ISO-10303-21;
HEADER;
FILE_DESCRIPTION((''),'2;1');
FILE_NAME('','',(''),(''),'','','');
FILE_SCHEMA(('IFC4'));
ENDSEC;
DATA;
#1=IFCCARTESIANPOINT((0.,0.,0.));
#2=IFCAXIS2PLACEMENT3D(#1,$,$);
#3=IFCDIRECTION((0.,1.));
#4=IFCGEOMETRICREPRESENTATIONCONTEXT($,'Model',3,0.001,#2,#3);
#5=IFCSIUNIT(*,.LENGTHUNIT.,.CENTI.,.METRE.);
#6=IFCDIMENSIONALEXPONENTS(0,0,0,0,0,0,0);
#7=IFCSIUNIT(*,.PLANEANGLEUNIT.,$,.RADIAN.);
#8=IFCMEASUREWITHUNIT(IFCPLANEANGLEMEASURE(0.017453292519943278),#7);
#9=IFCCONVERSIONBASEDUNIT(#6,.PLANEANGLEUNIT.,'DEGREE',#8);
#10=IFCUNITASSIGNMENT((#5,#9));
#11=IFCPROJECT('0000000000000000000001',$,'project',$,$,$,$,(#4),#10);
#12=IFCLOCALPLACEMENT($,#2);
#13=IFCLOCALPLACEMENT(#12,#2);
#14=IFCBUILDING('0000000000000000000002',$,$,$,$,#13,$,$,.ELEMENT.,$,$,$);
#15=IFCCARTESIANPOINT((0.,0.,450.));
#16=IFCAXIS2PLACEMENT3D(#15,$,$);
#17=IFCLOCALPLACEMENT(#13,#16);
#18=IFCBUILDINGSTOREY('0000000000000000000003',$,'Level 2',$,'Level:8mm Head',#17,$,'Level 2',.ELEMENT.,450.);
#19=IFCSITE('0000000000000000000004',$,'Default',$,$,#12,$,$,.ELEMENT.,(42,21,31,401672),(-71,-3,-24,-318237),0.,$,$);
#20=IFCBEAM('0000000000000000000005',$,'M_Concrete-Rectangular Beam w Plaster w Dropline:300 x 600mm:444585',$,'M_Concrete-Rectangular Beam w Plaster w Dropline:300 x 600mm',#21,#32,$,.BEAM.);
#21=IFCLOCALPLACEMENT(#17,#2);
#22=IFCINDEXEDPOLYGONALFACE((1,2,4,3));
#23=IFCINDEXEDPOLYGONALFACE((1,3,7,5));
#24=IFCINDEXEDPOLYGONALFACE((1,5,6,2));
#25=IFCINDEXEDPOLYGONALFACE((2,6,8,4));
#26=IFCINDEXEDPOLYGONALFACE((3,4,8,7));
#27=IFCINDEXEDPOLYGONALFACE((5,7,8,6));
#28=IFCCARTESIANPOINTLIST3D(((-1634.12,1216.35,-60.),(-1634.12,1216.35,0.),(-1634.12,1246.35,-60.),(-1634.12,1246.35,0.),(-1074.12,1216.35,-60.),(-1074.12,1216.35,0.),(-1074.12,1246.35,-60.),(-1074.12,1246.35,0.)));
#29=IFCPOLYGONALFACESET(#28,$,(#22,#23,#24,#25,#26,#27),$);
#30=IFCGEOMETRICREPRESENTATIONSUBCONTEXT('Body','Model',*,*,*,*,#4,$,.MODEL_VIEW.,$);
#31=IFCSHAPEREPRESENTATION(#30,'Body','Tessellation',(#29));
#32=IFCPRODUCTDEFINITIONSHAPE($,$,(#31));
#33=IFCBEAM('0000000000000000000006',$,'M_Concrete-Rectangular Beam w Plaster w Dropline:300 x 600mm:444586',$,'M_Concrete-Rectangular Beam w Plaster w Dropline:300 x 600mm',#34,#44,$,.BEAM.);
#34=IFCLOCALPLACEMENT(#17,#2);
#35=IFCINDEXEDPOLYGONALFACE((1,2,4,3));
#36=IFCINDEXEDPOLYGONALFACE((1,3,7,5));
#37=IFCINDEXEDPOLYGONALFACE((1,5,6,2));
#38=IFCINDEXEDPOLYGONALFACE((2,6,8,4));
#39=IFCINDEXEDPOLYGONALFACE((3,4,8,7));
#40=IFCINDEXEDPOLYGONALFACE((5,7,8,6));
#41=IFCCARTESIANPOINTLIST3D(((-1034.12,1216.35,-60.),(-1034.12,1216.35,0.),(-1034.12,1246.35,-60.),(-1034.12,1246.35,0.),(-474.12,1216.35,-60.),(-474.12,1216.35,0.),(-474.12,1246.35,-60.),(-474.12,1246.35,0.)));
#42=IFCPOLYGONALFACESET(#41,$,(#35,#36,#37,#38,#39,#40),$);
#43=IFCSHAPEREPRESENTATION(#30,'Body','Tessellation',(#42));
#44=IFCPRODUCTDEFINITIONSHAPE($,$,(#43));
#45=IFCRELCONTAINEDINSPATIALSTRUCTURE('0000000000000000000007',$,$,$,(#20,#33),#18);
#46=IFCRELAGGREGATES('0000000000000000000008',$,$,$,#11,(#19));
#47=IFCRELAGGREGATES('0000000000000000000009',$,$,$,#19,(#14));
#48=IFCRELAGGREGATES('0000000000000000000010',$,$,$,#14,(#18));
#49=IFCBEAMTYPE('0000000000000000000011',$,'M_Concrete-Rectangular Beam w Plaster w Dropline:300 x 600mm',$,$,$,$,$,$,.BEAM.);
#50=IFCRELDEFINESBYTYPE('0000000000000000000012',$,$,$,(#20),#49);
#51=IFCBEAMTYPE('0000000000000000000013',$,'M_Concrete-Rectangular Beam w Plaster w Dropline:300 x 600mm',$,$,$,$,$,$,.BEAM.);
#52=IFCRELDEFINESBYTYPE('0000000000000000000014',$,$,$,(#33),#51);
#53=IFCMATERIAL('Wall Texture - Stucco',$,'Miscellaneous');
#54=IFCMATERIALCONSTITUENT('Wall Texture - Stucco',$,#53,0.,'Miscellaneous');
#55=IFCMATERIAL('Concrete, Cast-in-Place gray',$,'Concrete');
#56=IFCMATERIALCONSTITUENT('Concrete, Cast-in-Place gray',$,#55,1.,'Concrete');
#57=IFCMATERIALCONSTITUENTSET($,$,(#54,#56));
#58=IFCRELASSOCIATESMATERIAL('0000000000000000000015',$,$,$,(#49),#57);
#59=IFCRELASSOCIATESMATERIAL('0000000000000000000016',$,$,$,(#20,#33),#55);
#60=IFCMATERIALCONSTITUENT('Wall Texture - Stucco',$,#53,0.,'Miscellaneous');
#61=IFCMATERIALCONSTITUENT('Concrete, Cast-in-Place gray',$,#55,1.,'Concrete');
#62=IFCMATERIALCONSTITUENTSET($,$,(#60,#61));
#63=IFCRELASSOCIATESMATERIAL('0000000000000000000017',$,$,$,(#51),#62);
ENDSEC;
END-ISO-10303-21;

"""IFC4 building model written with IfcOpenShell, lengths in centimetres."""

from ifc_helpers import new_model, entity, si_unit, converted_unit, direction, frame, origin, place, context, subcontext, project, spatial, indexed_curve, outline, extrude, source, transform, mapped, material, constituent, constituent_set, type_object, type_shapes, element, save


model = new_model("IFC4")

# Units and contexts
model_context = context("Model", 3, precision=0.001, world=origin(), true_north=direction((0.0, 1.0)))
body_context = subcontext(model_context, "Body", "Model", "MODEL_VIEW")
ifc_project = project(units=[si_unit("LENGTHUNIT", "METRE", prefix="CENTI"), converted_unit("PLANEANGLEUNIT", "DEGREE", entity("IfcPlaneAngleMeasure", 0.017453292519943278), si_unit("PLANEANGLEUNIT", "RADIAN"), dimensions=[0, 0, 0, 0, 0, 0, 0])], contexts=[model_context])

# Site, building, storey
site_placement = place(None, origin())
site = spatial("IfcSite", under=ifc_project, at=site_placement, Name="Default", CompositionType="ELEMENT", RefLatitude=(42, 21, 31, 401672), RefLongitude=(-71, -3, -24, -318237), RefElevation=0.0)
building_placement = place(site_placement, origin())
building = spatial("IfcBuilding", under=site, at=building_placement, CompositionType="ELEMENT")
storey_placement = place(building_placement, frame((0.0, 0.0, 450.0)))
storey = spatial("IfcBuildingStorey", under=building, at=storey_placement, Name="Level 2", ObjectType="Level:8mm Head", LongName="Level 2", CompositionType="ELEMENT", Elevation=450.0)

# Beams
ifc_material_1 = material(Name="Concrete, Cast-in-Place gray", Category="Concrete")
ifc_material_2 = material(Name="Wall Texture - Stucco", Category="Miscellaneous")
ifc_constituent_1 = constituent(ifc_material_2, Name="Wall Texture - Stucco", Category="Miscellaneous", fraction=0.0)
ifc_constituent_2 = constituent(ifc_material_1, Name="Concrete, Cast-in-Place gray", Category="Concrete", fraction=1.0)
ifc_constituent_set_1 = constituent_set(constituents=[ifc_constituent_1, ifc_constituent_2])
beam_type_1 = type_object("IfcBeamType", Name="M_Concrete-Rectangular Beam w Plaster w Dropline:300 x 600mm", PredefinedType="BEAM", material=ifc_constituent_set_1)
shared_shape_1 = source(origin(), body_context, "Body", "SweptSolid", [
    extrude(outline(indexed_curve([(-30.0, -15.0), (30.0, -15.0), (30.0, 15.0), (-30.0, 15.0), (-30.0, -15.0)], self_intersect=False)), frame((-1634.12, 1231.35, 420.0), z_axis=(1.0, 0.0, 0.0), x_axis=(0.0, 0.0, -1.0)), (0.0, 0.0, 1.0), 560.0),
])
type_shapes(beam_type_1, [shared_shape_1])
beam_1_placement = place(storey_placement, frame((0.0, 0.0, -450.0)))
element("IfcBeam", 1, at=beam_1_placement, inside=storey, type_object=beam_type_1, material=ifc_material_1, Name="M_Concrete-Rectangular Beam w Plaster w Dropline:300 x 600mm:444585", ObjectType="M_Concrete-Rectangular Beam w Plaster w Dropline:300 x 600mm", PredefinedType="BEAM", context=body_context, shape_type="MappedRepresentation", body=[
    mapped(shared_shape_1, transform((0.0, 0.0, 0.0), scale=1.0)),
])
ifc_constituent_3 = constituent(ifc_material_2, Name="Wall Texture - Stucco", Category="Miscellaneous", fraction=0.0)
ifc_constituent_4 = constituent(ifc_material_1, Name="Concrete, Cast-in-Place gray", Category="Concrete", fraction=1.0)
ifc_constituent_set_2 = constituent_set(constituents=[ifc_constituent_3, ifc_constituent_4])
beam_type_2 = type_object("IfcBeamType", Name="M_Concrete-Rectangular Beam w Plaster w Dropline:300 x 600mm", PredefinedType="BEAM", material=ifc_constituent_set_2)
shared_shape_2 = source(origin(), body_context, "Body", "SweptSolid", [
    extrude(outline(indexed_curve([(-30.0, -15.0), (30.0, -15.0), (30.0, 15.0), (-30.0, 15.0), (-30.0, -15.0)], self_intersect=False)), frame((-1034.12, 1231.35, 420.0), z_axis=(1.0, 0.0, 0.0), x_axis=(0.0, 0.0, -1.0)), (0.0, 0.0, 1.0), 560.0),
])
type_shapes(beam_type_2, [shared_shape_2])
beam_2_placement = place(storey_placement, frame((0.0, 0.0, -450.0)))
element("IfcBeam", 2, at=beam_2_placement, inside=storey, type_object=beam_type_2, material=ifc_material_1, Name="M_Concrete-Rectangular Beam w Plaster w Dropline:300 x 600mm:444586", ObjectType="M_Concrete-Rectangular Beam w Plaster w Dropline:300 x 600mm", PredefinedType="BEAM", context=body_context, shape_type="MappedRepresentation", body=[
    mapped(shared_shape_2, transform((0.0, 0.0, 0.0), scale=1.0)),
])

save(model, "model.ifc")
